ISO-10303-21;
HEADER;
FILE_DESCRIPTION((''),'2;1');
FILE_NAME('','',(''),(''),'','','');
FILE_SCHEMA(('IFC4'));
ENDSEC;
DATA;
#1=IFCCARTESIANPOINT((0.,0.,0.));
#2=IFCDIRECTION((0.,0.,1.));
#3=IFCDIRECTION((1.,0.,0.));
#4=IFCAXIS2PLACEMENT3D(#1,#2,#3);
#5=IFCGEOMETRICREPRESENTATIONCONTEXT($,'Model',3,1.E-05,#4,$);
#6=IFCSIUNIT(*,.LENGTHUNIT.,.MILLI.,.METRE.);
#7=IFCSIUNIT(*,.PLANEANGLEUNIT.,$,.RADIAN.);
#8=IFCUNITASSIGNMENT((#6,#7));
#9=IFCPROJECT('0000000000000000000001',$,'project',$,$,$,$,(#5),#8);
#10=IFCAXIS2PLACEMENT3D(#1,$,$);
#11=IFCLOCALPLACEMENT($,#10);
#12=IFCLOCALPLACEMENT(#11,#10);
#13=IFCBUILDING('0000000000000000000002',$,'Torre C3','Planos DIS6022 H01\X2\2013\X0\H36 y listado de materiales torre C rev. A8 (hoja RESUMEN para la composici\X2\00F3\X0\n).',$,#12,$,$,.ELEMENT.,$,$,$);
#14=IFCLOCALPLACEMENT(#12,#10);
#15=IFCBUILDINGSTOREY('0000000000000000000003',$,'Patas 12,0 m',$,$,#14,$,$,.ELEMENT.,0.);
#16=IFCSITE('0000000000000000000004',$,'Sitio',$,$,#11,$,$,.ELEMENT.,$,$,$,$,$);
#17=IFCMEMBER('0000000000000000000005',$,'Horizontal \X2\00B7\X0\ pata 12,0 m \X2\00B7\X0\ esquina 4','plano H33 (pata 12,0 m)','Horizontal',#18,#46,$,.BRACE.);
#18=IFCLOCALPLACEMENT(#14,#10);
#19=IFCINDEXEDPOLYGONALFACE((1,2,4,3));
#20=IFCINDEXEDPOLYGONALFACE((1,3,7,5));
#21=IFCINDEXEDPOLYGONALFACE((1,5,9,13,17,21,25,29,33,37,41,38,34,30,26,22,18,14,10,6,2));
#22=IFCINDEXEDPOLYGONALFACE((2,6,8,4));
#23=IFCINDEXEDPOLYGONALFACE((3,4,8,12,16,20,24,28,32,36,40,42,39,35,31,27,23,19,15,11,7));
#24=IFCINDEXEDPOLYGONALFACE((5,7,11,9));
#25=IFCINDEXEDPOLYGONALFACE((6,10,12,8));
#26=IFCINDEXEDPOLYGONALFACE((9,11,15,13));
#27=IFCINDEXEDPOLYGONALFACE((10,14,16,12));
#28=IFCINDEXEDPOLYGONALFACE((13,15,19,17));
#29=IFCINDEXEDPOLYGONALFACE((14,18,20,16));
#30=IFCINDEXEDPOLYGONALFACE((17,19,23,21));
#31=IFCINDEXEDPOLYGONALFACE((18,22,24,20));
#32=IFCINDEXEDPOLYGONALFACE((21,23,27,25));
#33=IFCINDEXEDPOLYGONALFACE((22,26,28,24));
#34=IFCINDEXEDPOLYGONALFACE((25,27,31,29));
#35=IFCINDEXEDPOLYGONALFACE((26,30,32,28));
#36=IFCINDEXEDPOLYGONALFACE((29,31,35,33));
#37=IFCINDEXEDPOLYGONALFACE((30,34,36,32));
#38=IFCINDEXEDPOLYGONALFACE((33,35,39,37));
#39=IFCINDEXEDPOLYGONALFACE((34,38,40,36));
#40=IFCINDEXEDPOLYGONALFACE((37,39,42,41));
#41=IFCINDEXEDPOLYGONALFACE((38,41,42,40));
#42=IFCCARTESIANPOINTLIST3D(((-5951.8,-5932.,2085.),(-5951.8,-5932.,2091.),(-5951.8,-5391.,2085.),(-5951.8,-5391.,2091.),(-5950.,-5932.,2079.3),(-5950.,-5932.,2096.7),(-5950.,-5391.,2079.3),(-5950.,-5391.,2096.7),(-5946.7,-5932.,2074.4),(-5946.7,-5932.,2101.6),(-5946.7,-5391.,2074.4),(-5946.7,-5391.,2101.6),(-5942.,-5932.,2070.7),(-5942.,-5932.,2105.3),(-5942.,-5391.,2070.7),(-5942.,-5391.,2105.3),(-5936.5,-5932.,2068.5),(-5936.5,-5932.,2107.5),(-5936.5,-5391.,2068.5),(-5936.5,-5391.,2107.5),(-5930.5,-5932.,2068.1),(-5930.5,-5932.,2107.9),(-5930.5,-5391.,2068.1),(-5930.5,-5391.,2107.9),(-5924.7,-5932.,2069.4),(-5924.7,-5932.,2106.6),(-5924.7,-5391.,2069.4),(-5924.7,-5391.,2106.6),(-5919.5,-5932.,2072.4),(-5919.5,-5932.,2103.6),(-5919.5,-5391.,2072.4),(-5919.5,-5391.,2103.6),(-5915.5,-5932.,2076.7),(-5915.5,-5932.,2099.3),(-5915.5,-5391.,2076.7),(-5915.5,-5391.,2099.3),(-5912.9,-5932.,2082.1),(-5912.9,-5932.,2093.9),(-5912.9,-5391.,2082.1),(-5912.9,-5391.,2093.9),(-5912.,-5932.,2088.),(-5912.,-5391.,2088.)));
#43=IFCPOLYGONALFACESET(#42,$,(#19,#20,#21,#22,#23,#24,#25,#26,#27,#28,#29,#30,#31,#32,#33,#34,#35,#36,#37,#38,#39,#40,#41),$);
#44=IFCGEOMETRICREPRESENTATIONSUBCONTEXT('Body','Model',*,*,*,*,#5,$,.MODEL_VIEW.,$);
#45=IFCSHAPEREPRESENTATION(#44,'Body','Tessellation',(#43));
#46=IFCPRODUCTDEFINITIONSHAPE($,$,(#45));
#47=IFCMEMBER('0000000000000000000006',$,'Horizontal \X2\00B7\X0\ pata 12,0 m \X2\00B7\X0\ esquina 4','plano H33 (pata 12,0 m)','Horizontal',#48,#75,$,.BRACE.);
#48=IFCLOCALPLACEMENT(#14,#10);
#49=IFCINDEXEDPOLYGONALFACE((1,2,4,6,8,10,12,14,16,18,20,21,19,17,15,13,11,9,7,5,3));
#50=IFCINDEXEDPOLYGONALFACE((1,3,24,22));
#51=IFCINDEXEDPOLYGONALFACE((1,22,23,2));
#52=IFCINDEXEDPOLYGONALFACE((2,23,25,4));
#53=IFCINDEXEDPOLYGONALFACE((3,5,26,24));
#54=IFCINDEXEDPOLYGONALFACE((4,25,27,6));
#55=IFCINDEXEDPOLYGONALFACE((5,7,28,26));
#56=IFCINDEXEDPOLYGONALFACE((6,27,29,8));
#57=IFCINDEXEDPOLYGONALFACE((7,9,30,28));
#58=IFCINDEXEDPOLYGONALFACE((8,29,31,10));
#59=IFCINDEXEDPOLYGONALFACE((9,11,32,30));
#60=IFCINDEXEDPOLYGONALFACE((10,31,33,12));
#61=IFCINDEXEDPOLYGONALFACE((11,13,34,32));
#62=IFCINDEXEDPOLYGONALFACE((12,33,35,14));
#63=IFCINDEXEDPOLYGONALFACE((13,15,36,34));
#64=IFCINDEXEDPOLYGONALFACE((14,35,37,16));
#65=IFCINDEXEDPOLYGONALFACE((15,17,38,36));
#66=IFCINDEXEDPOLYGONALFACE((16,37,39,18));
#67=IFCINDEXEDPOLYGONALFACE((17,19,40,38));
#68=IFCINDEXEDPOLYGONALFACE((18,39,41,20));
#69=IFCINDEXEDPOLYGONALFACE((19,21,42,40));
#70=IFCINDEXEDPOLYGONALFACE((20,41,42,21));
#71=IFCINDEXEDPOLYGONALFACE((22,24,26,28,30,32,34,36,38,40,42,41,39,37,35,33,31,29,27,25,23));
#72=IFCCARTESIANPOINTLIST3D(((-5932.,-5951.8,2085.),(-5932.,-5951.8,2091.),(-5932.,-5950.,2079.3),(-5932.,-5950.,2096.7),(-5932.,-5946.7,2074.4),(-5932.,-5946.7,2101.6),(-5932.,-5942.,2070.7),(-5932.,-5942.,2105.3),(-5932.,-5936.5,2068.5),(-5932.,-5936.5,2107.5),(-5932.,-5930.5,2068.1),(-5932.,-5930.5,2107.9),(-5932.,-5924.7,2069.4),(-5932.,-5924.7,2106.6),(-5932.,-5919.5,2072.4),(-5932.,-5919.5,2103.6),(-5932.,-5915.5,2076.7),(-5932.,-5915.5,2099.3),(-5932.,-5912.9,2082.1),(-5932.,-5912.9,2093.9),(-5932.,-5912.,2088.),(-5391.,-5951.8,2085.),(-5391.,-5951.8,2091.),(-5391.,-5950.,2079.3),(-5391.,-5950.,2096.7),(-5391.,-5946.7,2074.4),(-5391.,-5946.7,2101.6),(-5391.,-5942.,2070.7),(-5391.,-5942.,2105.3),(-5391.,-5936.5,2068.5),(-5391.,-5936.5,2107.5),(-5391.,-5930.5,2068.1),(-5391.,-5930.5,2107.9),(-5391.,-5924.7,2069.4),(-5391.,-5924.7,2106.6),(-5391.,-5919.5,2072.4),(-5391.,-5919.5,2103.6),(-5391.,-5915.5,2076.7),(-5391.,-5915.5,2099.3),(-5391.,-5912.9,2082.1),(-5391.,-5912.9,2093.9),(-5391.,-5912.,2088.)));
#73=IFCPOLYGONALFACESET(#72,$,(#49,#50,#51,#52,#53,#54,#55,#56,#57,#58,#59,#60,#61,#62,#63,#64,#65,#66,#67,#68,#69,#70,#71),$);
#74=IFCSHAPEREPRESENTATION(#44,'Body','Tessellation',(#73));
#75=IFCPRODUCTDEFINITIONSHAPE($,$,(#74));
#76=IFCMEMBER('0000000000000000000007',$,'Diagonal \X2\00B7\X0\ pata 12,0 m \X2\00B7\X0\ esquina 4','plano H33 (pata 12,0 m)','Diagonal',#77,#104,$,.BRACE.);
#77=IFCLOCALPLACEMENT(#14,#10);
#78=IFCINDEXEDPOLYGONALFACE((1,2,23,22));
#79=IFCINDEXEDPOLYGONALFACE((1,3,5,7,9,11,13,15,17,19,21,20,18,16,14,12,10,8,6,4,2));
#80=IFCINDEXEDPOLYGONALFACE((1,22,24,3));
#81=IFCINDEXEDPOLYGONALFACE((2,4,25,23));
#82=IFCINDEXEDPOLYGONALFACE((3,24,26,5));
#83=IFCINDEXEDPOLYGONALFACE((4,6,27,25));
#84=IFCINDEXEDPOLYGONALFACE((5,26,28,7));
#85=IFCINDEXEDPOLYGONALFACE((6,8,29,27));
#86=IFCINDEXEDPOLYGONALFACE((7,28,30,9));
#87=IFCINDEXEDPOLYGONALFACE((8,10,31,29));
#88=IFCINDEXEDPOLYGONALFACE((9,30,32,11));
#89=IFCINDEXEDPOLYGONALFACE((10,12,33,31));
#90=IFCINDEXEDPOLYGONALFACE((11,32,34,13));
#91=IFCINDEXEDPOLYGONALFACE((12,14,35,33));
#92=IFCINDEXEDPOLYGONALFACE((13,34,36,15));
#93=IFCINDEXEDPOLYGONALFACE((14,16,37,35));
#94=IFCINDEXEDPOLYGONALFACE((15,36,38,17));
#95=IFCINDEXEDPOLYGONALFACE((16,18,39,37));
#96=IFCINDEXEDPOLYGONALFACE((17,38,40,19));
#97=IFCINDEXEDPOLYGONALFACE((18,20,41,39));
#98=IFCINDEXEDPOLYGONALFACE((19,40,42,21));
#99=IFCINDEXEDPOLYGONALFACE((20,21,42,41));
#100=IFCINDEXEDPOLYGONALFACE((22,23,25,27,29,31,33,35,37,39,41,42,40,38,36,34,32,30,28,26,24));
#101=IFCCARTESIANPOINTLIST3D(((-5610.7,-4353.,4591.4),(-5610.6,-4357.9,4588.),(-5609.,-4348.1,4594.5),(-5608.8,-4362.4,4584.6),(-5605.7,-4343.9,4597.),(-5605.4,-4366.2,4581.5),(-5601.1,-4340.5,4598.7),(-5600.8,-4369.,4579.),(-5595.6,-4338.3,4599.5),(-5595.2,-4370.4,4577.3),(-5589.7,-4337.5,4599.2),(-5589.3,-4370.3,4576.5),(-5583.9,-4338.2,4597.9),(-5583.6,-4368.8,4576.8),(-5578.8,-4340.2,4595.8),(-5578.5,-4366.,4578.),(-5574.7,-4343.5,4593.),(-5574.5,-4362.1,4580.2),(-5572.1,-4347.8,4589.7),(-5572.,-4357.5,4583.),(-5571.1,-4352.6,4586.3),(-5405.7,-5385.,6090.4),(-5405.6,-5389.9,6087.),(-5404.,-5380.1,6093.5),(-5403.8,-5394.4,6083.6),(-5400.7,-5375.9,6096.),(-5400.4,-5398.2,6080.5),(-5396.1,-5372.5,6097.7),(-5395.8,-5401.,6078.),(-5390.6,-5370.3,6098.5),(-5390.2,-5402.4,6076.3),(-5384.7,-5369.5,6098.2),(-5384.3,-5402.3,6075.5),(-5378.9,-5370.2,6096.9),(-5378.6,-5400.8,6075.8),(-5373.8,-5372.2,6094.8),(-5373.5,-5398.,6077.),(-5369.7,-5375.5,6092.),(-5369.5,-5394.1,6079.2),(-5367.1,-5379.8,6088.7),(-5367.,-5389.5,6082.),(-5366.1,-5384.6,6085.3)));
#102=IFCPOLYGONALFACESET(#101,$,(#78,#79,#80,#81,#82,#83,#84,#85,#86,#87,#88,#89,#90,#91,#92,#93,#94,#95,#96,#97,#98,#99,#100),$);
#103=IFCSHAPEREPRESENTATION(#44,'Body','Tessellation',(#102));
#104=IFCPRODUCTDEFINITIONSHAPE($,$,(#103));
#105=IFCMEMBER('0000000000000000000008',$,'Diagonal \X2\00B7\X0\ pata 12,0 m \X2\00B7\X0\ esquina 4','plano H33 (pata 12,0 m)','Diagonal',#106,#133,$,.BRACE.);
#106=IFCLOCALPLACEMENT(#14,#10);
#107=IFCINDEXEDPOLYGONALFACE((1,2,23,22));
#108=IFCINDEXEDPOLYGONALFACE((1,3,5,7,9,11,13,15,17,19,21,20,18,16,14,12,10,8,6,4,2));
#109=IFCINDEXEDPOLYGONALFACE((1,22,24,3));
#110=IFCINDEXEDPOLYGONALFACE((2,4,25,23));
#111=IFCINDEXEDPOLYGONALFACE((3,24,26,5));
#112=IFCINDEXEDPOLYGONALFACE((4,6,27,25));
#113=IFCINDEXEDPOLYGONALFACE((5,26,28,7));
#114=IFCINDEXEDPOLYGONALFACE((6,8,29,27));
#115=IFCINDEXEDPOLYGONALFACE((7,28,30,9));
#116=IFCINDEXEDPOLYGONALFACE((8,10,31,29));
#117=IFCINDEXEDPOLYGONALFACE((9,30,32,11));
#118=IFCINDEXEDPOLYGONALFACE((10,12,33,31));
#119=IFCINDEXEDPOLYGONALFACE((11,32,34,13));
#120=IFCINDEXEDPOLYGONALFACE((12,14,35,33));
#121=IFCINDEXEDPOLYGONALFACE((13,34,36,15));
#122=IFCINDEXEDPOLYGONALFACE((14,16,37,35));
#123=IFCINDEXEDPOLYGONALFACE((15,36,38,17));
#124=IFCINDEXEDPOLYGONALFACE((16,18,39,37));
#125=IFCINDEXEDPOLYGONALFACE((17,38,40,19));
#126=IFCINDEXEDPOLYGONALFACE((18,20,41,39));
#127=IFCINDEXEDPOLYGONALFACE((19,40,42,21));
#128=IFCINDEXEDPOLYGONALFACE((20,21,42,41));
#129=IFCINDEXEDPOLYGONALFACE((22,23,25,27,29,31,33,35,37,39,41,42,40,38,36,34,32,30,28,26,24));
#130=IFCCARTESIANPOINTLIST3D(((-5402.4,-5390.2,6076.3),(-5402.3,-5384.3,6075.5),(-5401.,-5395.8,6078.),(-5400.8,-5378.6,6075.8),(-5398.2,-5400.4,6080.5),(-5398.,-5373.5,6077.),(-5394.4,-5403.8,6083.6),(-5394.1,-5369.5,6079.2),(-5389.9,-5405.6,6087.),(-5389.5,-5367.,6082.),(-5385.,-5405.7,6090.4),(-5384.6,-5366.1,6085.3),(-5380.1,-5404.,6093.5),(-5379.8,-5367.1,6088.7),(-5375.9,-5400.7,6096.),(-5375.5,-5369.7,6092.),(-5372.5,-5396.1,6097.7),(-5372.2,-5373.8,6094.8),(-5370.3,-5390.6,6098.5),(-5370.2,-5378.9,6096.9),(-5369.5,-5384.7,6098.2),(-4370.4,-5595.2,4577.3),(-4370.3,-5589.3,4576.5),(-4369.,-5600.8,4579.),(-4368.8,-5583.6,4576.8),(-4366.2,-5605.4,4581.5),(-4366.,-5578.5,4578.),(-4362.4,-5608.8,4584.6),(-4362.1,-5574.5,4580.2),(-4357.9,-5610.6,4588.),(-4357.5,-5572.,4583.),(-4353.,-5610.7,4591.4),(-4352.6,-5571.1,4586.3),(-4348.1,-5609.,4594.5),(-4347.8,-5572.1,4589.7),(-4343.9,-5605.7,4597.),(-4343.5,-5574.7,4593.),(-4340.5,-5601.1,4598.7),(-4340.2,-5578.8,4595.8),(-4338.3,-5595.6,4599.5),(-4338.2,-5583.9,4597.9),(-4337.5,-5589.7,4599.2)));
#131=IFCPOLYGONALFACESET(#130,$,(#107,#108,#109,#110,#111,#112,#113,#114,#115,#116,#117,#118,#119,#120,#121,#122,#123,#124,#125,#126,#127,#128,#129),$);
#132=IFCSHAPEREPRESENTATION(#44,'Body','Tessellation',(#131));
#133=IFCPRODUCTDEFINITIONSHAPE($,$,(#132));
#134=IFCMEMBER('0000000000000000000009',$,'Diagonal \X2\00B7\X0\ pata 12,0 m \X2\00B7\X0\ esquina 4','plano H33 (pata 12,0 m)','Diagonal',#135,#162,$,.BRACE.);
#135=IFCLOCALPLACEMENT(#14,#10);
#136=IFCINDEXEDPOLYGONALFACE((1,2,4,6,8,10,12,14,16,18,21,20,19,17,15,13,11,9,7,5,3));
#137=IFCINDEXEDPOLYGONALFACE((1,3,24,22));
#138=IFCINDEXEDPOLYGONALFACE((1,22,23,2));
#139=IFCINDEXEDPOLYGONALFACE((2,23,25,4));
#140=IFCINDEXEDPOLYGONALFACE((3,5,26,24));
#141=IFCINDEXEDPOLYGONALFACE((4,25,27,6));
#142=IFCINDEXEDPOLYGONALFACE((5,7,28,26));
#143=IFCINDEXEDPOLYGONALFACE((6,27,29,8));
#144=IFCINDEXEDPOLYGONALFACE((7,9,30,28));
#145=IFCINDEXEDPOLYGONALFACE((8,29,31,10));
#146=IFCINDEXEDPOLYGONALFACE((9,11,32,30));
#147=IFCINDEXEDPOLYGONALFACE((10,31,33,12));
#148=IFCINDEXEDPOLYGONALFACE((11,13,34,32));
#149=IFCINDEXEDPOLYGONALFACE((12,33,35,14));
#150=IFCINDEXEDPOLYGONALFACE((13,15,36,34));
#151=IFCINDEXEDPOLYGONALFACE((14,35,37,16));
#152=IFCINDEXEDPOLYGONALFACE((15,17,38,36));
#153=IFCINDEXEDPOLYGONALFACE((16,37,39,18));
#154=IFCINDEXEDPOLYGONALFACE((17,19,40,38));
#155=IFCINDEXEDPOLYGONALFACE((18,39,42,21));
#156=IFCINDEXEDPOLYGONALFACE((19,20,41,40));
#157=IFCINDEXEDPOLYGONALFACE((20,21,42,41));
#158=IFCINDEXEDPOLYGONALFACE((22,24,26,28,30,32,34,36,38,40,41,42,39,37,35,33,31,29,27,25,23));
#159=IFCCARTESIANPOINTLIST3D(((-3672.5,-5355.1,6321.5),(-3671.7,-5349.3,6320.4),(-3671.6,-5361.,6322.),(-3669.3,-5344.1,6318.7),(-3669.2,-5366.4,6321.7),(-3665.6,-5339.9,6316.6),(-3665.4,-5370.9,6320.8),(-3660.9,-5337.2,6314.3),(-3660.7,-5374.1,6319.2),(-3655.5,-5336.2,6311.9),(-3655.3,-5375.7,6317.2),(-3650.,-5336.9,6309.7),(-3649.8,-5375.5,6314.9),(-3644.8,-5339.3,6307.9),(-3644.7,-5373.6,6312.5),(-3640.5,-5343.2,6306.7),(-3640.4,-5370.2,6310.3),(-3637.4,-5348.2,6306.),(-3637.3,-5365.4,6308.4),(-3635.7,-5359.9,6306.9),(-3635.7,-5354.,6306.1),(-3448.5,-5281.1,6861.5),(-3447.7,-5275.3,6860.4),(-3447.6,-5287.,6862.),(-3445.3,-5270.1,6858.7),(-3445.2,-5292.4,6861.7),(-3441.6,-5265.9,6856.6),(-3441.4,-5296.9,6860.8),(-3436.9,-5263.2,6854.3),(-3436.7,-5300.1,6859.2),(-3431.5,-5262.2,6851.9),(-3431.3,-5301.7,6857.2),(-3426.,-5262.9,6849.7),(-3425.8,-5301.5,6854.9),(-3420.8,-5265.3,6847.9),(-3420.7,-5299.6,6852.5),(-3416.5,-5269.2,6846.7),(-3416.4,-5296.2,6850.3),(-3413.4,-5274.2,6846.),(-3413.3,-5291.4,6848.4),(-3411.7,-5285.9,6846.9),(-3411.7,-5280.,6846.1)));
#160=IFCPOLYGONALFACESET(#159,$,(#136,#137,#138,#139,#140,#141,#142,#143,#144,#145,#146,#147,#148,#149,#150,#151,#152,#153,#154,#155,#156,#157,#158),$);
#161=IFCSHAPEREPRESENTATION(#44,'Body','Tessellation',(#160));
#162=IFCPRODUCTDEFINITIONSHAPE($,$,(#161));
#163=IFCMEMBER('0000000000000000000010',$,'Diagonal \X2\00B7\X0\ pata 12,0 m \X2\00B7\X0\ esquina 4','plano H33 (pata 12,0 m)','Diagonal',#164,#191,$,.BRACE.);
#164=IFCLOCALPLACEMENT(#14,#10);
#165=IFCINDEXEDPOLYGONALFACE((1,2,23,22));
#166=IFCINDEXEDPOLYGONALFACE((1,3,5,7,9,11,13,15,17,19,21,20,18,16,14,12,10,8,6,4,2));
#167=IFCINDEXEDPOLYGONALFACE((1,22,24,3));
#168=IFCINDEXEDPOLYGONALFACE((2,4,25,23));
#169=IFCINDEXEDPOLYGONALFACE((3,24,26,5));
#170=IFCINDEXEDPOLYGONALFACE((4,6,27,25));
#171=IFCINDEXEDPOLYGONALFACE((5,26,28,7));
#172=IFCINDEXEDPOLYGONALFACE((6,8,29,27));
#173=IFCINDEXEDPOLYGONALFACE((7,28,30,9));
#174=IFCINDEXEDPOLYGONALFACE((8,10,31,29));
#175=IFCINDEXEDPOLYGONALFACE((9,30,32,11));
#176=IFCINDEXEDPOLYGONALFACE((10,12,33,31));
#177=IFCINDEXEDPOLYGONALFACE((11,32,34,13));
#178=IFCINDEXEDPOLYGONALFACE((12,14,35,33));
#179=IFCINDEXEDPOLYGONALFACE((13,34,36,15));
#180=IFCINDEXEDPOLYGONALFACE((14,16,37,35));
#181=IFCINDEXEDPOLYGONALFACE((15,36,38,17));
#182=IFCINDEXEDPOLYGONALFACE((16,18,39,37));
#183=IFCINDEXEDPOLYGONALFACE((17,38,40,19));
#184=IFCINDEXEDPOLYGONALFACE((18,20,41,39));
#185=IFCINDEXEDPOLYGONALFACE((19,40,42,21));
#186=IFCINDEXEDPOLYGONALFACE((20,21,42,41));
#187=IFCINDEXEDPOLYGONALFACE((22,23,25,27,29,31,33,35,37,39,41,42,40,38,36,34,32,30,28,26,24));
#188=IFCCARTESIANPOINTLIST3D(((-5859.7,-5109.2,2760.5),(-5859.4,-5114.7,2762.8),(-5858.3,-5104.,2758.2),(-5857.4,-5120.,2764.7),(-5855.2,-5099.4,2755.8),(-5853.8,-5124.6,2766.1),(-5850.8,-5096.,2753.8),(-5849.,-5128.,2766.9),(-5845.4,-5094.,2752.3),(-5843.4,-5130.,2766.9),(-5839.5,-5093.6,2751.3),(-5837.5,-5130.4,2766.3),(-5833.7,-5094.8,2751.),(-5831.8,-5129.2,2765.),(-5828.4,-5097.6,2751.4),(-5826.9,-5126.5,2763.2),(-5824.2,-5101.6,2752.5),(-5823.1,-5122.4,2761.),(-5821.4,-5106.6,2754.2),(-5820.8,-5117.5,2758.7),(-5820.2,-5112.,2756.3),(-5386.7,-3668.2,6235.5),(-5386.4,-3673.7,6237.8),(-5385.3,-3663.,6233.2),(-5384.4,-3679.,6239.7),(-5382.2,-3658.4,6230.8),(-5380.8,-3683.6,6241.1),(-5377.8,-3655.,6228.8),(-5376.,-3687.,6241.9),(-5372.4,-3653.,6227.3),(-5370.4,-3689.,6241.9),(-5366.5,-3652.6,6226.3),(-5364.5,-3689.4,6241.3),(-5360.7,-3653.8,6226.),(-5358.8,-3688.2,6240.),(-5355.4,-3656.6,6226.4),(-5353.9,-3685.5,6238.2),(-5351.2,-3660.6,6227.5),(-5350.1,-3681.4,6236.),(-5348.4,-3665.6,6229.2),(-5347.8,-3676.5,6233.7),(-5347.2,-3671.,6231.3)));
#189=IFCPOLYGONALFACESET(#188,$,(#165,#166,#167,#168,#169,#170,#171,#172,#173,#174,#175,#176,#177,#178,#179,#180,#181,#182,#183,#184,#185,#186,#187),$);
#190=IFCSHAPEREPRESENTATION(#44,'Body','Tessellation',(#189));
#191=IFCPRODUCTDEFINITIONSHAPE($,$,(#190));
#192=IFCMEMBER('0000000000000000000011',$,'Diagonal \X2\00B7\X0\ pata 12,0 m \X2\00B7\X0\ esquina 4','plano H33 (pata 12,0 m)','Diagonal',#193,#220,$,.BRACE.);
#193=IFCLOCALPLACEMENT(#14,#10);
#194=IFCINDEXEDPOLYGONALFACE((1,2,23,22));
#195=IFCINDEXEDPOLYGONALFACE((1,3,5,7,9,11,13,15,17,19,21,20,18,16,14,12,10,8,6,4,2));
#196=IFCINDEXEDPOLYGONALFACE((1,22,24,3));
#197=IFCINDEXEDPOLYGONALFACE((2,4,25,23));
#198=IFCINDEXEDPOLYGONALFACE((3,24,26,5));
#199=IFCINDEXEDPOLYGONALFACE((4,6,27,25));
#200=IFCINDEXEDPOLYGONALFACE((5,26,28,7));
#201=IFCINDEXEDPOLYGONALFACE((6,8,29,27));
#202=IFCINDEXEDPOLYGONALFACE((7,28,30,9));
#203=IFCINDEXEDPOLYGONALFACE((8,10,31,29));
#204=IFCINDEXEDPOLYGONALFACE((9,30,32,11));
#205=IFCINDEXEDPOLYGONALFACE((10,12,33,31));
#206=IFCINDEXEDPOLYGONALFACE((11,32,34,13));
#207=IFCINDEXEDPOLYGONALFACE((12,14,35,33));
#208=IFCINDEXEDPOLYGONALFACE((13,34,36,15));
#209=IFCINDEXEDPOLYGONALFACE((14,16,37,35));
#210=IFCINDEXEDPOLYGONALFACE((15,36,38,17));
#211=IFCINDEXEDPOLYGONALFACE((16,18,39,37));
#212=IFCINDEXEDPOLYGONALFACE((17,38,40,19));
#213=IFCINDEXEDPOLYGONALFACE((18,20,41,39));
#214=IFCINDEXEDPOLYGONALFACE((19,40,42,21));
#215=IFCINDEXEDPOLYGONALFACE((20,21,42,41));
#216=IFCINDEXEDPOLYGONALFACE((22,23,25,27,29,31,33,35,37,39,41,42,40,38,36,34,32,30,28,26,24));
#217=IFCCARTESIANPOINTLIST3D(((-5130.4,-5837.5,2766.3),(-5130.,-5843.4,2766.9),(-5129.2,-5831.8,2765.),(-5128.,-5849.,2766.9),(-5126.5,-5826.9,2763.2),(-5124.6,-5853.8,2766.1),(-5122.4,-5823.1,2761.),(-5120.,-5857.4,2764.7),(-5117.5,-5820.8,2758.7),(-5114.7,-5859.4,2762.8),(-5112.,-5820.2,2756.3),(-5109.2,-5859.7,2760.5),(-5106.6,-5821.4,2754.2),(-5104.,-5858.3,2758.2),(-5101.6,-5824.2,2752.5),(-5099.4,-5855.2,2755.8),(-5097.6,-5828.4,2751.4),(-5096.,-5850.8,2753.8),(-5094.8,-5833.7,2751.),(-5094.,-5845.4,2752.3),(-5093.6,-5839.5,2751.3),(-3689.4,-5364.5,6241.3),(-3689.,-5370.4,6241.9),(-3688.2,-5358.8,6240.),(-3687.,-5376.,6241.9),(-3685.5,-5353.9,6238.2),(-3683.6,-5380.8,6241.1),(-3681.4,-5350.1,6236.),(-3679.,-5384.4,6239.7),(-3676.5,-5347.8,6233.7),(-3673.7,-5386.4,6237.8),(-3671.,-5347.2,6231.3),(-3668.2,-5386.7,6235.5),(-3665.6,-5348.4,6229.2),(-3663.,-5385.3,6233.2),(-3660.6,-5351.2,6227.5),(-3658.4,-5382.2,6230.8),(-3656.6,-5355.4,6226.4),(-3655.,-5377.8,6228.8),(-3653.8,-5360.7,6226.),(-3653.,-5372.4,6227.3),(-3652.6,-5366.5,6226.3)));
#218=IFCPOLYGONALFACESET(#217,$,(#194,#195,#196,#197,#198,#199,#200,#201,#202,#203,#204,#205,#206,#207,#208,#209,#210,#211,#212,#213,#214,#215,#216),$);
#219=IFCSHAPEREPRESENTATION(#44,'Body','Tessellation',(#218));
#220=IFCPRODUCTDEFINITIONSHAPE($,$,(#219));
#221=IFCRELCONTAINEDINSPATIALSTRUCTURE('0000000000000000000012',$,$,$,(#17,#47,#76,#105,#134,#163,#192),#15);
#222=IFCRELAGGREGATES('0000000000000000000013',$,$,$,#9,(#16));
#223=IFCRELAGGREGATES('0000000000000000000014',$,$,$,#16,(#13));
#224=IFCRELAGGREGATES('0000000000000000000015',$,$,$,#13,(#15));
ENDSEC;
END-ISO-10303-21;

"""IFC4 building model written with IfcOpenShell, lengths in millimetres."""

from ifc_helpers import new_model, si_unit, frame, origin, origin_with_axes, place, context, subcontext, project, spatial, circle, extrude, element, save


model = new_model("IFC4")

# Units and contexts
model_context = context("Model", 3, precision=1e-05, world=origin_with_axes())
body_context = subcontext(model_context, "Body", "Model", "MODEL_VIEW")
ifc_project = project(units=[si_unit("LENGTHUNIT", "METRE", prefix="MILLI"), si_unit("PLANEANGLEUNIT", "RADIAN")], contexts=[model_context])

# Site, building, storey
site_placement = place(None, origin())
site = spatial("IfcSite", under=ifc_project, at=site_placement, Name="Sitio", CompositionType="ELEMENT")
building_placement = place(site_placement, origin())
building = spatial("IfcBuilding", under=site, at=building_placement, Name="Torre C3", Description="Planos DIS6022 H01–H36 y listado de materiales torre C rev. A8 (hoja RESUMEN para la composición).", CompositionType="ELEMENT")
storey_placement = place(building_placement, origin())
storey = spatial("IfcBuildingStorey", under=building, at=storey_placement, Name="Patas 12,0 m", CompositionType="ELEMENT", Elevation=0.0)

# Members
for number, where, z_axis, x_axis, name in (
    (1, (-5932.0, -5391.0, 2088.0), (0.0, -1.0, 0.0), (1.0, 0.0, 0.0), "Horizontal · pata 12,0 m · esquina 4"),
    (2, (-5391.0, -5932.0, 2088.0), (-1.0, 0.0, 0.0), (0.0, 1.0, 0.0), "Horizontal · pata 12,0 m · esquina 4"),
):
    element("IfcMember", number, at=place(storey_placement, frame(where, z_axis=z_axis, x_axis=x_axis)), inside=storey, Name=name, Description="plano H33 (pata 12,0 m)", ObjectType="Horizontal", PredefinedType="BRACE", context=body_context, shape_type="SweptSolid", body=[
        extrude(circle(Radius=20.0), None, (0.0, 0.0, 1.0), 541.0),
    ])
for number, where, z_axis, x_axis, name in (
    (3, (-5386.0, -5386.0, 6087.0), (-0.111936, 0.563501, -0.818497), (0.815603, 0.522638, 0.248275), "Diagonal · pata 12,0 m · esquina 4"),
    (4, (-5386.0, -5386.0, 6087.0), (0.563501, -0.111936, -0.818497), (0.522638, 0.815603, 0.248275), "Diagonal · pata 12,0 m · esquina 4"),
):
    element("IfcMember", number, at=place(storey_placement, frame(where, z_axis=z_axis, x_axis=x_axis)), inside=storey, Name=name, Description="plano H33 (pata 12,0 m)", ObjectType="Diagonal", PredefinedType="BRACE", context=body_context, shape_type="SweptSolid", body=[
        extrude(circle(Radius=20.0), None, (0.0, 0.0, 1.0), 1831.4),
    ])
member_1_placement = place(storey_placement, frame((-3430.0, -5282.0, 6854.0), z_axis=(-0.380124, -0.125577, -0.916371), x_axis=(0.457784, 0.83534, -0.304368)))
element("IfcMember", 5, at=member_1_placement, inside=storey, Name="Diagonal · pata 12,0 m · esquina 4", Description="plano H33 (pata 12,0 m)", ObjectType="Diagonal", PredefinedType="BRACE", context=body_context, shape_type="SweptSolid", body=[
    extrude(circle(Radius=20.0), None, (0.0, 0.0, 1.0), 589.3),
])
for number, where, z_axis, x_axis, name in (
    (6, (-5367.0, -3671.0, 6234.0), (-0.124751, -0.380056, -0.916512), (0.790608, 0.520039, -0.323262), "Diagonal · pata 12,0 m · esquina 4"),
    (7, (-3671.0, -5367.0, 6234.0), (-0.380056, -0.124751, -0.916512), (0.520039, 0.790608, -0.323262), "Diagonal · pata 12,0 m · esquina 4"),
):
    element("IfcMember", number, at=place(storey_placement, frame(where, z_axis=z_axis, x_axis=x_axis)), inside=storey, Name=name, Description="plano H33 (pata 12,0 m)", ObjectType="Diagonal", PredefinedType="BRACE", context=body_context, shape_type="SweptSolid", body=[
        extrude(circle(Radius=20.0), None, (0.0, 0.0, 1.0), 3791.5),
    ])

save(model, "model.ifc")
